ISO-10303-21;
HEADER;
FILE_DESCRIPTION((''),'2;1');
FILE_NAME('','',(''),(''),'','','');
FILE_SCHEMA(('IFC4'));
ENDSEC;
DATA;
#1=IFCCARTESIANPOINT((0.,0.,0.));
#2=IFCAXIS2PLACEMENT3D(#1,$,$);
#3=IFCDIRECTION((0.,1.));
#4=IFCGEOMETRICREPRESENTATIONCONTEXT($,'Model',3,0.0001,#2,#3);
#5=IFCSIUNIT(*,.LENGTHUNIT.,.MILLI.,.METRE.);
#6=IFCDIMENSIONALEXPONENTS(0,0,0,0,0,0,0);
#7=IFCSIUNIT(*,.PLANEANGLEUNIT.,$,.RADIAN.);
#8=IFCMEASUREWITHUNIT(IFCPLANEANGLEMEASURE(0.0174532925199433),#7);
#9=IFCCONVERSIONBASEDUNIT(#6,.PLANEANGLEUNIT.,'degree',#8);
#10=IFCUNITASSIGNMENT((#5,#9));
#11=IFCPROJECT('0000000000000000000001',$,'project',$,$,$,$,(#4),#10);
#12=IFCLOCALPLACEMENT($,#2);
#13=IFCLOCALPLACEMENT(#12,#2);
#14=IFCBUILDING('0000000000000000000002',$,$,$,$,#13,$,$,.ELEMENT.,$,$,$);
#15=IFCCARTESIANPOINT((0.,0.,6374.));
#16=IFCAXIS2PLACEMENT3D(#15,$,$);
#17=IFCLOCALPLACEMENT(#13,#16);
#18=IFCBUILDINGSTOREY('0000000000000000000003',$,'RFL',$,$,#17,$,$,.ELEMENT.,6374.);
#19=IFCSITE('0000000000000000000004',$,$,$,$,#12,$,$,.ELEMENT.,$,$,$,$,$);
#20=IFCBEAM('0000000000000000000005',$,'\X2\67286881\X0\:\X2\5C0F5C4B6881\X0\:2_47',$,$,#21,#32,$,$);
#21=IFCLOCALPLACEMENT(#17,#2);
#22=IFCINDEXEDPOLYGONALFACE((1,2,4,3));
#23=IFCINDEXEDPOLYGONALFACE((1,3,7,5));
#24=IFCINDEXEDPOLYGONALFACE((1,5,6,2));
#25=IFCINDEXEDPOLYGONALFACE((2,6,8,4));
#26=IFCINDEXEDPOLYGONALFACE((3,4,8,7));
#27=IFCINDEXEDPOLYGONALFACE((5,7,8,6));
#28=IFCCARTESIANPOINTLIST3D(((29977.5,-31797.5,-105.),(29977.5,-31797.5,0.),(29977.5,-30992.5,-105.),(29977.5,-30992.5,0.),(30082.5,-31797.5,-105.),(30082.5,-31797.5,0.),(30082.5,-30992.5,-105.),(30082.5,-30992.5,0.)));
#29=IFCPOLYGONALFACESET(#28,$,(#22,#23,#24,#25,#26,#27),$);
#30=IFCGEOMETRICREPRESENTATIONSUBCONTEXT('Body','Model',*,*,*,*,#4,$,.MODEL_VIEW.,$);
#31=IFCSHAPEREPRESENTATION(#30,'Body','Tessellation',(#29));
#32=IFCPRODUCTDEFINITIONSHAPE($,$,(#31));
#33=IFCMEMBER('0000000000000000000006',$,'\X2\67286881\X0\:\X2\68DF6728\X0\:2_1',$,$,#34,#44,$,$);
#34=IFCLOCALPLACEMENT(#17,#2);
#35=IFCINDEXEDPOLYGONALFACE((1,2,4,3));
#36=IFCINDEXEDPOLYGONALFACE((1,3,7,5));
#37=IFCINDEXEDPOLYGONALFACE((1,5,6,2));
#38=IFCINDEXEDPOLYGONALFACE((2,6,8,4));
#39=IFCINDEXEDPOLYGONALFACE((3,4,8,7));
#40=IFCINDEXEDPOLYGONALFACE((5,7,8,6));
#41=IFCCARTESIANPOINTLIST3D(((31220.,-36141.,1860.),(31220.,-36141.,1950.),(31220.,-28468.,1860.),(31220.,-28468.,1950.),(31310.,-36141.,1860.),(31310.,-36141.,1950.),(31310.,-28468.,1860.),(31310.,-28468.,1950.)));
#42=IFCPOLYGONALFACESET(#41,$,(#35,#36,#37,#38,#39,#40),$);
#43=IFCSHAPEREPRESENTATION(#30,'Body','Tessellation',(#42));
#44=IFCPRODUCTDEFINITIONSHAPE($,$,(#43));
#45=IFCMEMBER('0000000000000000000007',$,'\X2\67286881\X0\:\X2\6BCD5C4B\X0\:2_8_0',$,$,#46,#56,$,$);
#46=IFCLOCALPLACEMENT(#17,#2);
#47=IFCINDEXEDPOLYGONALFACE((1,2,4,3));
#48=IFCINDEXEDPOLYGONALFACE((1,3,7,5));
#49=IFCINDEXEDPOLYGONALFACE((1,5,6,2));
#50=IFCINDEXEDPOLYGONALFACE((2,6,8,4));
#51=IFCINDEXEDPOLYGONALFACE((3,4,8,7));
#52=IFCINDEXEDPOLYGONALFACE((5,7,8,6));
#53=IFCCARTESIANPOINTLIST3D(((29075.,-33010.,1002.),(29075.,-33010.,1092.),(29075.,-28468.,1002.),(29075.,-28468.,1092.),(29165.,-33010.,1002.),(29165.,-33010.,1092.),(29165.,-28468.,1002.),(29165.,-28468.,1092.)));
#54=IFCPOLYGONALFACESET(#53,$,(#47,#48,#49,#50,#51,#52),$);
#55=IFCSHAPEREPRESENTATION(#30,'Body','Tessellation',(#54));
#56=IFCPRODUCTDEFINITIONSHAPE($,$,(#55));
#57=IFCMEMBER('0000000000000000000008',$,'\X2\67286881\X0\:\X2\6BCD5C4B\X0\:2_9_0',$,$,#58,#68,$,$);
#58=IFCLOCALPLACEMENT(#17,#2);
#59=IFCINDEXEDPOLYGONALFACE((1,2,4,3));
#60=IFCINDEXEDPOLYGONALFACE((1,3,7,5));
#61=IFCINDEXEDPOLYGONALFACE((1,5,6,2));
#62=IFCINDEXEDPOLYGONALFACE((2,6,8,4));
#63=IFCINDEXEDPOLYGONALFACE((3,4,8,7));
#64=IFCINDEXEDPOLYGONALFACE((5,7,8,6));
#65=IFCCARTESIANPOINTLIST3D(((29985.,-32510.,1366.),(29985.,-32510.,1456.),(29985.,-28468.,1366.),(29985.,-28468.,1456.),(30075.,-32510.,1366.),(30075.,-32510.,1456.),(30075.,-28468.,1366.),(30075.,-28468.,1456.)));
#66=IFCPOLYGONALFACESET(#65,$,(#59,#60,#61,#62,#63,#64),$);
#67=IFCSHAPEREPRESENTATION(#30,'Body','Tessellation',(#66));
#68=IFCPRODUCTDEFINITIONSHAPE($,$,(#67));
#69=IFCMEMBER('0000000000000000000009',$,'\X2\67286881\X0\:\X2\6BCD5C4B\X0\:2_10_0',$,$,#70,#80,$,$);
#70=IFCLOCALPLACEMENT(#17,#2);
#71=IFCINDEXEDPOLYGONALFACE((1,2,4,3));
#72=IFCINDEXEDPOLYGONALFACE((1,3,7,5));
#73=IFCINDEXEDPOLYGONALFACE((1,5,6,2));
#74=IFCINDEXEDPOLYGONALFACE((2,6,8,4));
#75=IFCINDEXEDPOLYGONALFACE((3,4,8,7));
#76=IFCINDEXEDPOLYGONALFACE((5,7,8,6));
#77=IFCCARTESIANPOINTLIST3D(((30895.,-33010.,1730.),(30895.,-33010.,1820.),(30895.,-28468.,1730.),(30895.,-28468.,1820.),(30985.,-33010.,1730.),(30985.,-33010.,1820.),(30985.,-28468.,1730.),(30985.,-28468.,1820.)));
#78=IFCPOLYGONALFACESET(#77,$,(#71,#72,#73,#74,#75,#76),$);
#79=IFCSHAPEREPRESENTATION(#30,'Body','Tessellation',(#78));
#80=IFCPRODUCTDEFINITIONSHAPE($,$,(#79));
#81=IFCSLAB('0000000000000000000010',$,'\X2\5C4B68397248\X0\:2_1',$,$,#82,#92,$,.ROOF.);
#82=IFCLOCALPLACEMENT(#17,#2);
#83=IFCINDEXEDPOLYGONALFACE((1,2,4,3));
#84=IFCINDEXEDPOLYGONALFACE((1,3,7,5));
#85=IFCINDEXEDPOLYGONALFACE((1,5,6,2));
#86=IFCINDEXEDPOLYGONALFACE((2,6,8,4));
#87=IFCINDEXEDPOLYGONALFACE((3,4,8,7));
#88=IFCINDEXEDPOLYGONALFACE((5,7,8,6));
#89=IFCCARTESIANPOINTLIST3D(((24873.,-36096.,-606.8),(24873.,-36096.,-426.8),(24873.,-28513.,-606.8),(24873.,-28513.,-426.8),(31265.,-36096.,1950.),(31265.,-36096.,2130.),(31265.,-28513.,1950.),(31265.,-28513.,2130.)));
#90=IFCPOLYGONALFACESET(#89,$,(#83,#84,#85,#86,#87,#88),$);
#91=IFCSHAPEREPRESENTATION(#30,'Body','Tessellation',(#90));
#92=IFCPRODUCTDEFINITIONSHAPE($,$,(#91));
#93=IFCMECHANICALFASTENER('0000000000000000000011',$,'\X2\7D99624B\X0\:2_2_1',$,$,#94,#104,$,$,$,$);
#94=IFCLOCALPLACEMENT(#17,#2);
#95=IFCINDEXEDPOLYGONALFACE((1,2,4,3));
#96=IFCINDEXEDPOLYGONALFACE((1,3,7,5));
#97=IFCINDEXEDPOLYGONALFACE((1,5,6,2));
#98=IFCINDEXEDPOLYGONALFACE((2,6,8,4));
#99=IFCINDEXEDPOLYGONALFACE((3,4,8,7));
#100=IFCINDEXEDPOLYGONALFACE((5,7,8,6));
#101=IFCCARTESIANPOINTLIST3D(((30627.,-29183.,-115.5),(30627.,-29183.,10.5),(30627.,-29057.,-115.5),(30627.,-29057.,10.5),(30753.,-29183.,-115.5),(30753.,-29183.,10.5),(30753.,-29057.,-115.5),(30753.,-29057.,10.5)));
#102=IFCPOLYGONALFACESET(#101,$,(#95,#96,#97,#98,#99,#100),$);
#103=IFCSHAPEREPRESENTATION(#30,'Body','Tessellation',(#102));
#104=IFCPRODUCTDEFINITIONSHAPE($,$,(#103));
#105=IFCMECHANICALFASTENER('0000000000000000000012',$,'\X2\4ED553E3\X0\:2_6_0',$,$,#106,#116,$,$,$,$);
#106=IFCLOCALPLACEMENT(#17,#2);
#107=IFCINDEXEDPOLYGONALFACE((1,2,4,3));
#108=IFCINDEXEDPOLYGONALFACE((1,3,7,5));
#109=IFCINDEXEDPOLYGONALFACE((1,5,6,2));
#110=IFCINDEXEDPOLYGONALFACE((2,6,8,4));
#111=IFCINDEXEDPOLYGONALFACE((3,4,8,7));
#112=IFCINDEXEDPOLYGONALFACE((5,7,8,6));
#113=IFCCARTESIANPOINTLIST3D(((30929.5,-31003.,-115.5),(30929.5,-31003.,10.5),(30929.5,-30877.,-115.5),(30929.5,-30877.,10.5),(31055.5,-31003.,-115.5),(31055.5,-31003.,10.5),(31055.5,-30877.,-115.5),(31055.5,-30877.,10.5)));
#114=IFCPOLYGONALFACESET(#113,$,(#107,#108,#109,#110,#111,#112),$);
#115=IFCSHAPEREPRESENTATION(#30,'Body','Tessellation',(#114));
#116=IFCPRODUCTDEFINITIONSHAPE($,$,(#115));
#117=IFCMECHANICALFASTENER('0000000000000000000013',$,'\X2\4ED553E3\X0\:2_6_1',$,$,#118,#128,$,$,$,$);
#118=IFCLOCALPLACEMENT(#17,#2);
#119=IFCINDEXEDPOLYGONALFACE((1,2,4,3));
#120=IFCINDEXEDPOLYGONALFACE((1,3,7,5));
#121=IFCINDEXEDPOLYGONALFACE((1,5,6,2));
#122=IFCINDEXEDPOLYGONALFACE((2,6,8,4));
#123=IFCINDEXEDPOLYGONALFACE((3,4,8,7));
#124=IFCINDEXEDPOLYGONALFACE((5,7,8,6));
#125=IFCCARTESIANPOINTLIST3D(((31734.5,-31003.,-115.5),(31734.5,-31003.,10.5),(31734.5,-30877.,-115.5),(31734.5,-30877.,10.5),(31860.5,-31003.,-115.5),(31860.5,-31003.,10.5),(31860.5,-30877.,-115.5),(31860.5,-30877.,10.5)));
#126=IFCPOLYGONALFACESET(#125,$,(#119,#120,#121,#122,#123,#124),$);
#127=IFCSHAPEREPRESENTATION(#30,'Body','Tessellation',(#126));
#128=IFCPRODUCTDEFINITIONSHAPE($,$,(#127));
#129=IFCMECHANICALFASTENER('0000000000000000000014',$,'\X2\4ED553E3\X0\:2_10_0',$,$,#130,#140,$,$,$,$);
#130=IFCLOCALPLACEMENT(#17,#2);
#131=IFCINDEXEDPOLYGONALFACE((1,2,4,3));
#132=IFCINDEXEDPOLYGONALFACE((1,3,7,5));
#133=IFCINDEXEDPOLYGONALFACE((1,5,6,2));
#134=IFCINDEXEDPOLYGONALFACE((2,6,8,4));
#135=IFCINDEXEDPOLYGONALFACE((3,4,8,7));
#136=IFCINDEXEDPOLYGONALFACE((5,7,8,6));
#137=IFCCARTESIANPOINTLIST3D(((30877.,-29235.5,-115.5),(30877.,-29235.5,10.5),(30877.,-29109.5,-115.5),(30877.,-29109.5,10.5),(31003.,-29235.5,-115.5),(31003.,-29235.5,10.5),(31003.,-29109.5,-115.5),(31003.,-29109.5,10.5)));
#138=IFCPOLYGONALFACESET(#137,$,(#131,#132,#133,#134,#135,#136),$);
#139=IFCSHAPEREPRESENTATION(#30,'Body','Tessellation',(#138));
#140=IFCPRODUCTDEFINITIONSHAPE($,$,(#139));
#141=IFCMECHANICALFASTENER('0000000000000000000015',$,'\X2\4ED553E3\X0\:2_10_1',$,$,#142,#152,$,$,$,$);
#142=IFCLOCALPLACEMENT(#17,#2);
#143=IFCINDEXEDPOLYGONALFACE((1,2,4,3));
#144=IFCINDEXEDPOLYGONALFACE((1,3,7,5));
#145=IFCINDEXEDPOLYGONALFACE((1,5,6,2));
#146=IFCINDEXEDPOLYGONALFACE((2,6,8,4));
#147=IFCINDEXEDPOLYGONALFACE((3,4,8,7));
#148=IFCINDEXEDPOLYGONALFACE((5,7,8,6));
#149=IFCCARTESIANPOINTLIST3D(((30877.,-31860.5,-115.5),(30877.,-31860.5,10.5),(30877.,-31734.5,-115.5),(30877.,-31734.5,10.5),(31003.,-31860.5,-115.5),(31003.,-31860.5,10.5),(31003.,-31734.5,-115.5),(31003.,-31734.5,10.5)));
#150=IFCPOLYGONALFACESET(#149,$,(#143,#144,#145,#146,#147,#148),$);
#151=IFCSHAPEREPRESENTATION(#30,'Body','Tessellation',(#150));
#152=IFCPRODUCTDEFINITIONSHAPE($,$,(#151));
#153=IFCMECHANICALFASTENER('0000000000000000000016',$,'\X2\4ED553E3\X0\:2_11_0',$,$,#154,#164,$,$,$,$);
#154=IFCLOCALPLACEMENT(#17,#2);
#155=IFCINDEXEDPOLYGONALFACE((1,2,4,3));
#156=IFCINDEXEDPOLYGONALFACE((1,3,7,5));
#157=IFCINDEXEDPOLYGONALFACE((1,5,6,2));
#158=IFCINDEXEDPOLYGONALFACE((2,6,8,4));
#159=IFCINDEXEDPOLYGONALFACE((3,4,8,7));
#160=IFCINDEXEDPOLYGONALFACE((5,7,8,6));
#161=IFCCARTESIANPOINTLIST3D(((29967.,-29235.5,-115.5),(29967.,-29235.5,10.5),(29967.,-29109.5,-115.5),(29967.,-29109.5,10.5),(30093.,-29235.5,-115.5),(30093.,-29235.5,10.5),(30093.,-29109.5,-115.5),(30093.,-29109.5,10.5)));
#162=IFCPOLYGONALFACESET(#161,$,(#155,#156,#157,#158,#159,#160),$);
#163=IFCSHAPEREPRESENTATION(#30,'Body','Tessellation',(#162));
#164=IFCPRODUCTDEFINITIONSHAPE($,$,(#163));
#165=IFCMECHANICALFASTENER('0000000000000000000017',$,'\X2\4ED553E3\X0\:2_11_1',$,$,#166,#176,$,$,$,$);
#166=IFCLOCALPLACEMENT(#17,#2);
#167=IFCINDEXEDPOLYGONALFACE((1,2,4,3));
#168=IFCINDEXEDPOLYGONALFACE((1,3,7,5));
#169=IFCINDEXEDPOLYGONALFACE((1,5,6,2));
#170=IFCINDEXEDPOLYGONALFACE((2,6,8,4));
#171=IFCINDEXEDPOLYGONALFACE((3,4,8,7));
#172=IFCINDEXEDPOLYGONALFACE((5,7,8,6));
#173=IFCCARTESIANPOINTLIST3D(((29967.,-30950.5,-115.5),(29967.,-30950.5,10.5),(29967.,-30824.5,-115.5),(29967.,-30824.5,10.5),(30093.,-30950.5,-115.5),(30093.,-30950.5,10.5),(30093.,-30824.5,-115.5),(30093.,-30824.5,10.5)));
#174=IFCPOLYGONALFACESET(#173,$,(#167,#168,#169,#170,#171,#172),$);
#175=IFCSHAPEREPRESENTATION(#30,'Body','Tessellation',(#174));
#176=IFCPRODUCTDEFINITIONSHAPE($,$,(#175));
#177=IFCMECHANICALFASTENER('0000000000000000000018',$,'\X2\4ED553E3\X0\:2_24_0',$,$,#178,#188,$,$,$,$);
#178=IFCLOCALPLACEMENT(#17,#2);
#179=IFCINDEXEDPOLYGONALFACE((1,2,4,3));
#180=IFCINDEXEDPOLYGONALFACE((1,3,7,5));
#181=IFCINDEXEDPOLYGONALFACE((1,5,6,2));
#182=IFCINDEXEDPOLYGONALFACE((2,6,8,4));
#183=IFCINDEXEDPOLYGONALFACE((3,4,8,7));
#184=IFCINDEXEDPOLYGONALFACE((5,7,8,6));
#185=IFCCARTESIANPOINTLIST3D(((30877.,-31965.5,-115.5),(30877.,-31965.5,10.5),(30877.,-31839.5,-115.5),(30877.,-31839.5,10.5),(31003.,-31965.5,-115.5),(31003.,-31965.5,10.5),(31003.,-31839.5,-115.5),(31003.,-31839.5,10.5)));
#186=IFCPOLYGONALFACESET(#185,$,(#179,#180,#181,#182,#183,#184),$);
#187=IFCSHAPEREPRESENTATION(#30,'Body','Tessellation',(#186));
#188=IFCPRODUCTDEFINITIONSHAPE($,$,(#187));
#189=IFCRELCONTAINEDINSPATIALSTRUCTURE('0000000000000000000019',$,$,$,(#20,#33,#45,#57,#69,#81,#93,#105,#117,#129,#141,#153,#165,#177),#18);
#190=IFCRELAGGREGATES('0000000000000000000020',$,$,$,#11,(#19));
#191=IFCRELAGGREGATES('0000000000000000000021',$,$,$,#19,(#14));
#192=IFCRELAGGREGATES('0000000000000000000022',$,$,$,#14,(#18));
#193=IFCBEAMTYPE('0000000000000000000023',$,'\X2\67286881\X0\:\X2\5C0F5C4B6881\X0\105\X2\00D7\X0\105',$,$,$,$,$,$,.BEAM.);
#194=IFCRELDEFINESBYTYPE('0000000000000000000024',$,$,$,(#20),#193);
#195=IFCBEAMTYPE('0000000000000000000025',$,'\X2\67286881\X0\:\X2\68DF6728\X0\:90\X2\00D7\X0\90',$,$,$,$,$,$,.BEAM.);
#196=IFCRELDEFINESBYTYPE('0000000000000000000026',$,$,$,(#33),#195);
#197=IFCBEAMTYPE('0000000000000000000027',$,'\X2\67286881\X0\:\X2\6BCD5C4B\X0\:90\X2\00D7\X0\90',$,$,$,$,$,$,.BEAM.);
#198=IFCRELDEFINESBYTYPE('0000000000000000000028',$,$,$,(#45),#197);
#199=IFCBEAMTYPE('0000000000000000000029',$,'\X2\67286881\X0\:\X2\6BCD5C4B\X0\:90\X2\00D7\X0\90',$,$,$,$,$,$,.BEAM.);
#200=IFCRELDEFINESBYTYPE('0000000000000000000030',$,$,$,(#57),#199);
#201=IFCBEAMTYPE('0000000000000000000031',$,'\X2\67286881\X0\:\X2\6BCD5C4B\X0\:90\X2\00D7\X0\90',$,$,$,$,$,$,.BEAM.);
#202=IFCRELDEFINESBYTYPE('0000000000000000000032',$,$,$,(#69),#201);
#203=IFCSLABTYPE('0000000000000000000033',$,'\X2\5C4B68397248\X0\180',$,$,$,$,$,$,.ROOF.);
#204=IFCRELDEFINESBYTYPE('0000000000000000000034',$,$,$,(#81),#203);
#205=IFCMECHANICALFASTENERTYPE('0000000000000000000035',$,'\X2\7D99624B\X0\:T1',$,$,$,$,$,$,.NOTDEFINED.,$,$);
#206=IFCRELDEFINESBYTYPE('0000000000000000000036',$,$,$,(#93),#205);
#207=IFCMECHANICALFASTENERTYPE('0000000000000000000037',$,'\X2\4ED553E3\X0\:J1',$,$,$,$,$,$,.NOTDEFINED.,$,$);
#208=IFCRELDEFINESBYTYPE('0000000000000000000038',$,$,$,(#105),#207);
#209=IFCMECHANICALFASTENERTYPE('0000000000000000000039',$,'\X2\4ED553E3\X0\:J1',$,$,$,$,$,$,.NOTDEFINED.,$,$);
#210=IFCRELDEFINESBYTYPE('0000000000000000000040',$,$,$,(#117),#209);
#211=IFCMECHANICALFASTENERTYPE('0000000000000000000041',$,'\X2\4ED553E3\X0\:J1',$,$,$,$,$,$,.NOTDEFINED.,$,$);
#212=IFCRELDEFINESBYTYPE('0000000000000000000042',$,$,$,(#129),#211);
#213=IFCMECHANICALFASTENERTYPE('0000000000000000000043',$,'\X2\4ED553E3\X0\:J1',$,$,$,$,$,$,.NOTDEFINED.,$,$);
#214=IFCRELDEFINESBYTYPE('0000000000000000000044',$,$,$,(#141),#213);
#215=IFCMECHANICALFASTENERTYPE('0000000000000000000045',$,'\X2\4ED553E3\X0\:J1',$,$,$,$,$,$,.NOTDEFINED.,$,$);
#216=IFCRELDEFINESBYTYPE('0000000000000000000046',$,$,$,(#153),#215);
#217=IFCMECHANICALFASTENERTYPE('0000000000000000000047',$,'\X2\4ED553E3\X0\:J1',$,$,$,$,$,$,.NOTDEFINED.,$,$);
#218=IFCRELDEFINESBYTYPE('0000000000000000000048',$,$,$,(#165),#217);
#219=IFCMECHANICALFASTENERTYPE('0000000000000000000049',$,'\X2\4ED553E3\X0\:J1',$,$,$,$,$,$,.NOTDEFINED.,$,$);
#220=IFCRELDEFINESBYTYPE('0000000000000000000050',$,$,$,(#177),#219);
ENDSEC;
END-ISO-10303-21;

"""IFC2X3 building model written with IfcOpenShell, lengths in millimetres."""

from ifc_helpers import new_model, entity, si_unit, converted_unit, direction, frame, origin, origin_with_axes, origin_2d, place, context, subcontext, project, spatial, polyline, rectangle, outline, extrude, type_object, element, save


model = new_model("IFC2X3")

# Units and contexts
model_context = context("Model", 3, precision=0.0001, world=origin(), true_north=direction((0.0, 1.0)))
body_context = subcontext(model_context, "Body", "Model", "MODEL_VIEW")
ifc_project = project(units=[si_unit("LENGTHUNIT", "METRE", prefix="MILLI"), converted_unit("PLANEANGLEUNIT", "degree", entity("IfcPlaneAngleMeasure", 0.0174532925199433), si_unit("PLANEANGLEUNIT", "RADIAN"), dimensions=[0, 0, 0, 0, 0, 0, 0])], contexts=[model_context])

# Site, building, storey
site_placement = place(None, origin())
site = spatial("IfcSite", under=ifc_project, at=site_placement, CompositionType="ELEMENT")
building_placement = place(site_placement, origin())
building = spatial("IfcBuilding", under=site, at=building_placement, CompositionType="ELEMENT")
storey_placement = place(building_placement, frame((0.0, 0.0, 6374.0)))
storey = spatial("IfcBuildingStorey", under=building, at=storey_placement, Name="RFL", CompositionType="ELEMENT", Elevation=6374.0)

# Beam
beam_type_1 = type_object("IfcBeamType", Name="木梁:小屋梁105×105", PredefinedType="BEAM")
beam_1_placement = place(storey_placement, frame((30030.0, -30992.5, -52.5), z_axis=(0.0, -1.0, 0.0), x_axis=(1.0, 0.0, 0.0)))
element("IfcBeam", 1, at=beam_1_placement, inside=storey, type_object=beam_type_1, Name="木梁:小屋梁:2_47", context=body_context, shape_type="SweptSolid", body=[
    extrude(rectangle(XDim=105.0, YDim=105.0, at=origin_2d()), origin_with_axes(), (0.0, 0.0, 1.0), 805.0),
])

# Members
beam_type_2 = type_object("IfcBeamType", Name="木梁:棟木:90×90", PredefinedType="BEAM")
member_1_placement = place(storey_placement, frame((31265.0, -28468.0, 1905.0), z_axis=(0.0, -1.0, 0.0), x_axis=(-1.0, 0.0, 0.0)))
element("IfcMember", 2, at=member_1_placement, inside=storey, type_object=beam_type_2, Name="木梁:棟木:2_1", context=body_context, shape_type="SweptSolid", body=[
    extrude(rectangle(XDim=90.0, YDim=90.0, at=origin_2d()), origin_with_axes(), (0.0, 0.0, 1.0), 7673.0),
])
beam_type_3 = type_object("IfcBeamType", Name="木梁:母屋:90×90", PredefinedType="BEAM")
member_2_placement = place(storey_placement, frame((29120.0, -28468.0, 1047.0), z_axis=(0.0, -1.0, 0.0), x_axis=(-1.0, 0.0, 0.0)))
element("IfcMember", 3, at=member_2_placement, inside=storey, type_object=beam_type_3, Name="木梁:母屋:2_8_0", context=body_context, shape_type="SweptSolid", body=[
    extrude(rectangle(XDim=90.0, YDim=90.0, at=origin_2d()), origin_with_axes(), (0.0, 0.0, 1.0), 4542.0),
])
beam_type_4 = type_object("IfcBeamType", Name="木梁:母屋:90×90", PredefinedType="BEAM")
member_3_placement = place(storey_placement, frame((30030.0, -28468.0, 1411.0), z_axis=(0.0, -1.0, 0.0), x_axis=(-1.0, 0.0, 0.0)))
element("IfcMember", 4, at=member_3_placement, inside=storey, type_object=beam_type_4, Name="木梁:母屋:2_9_0", context=body_context, shape_type="SweptSolid", body=[
    extrude(rectangle(XDim=90.0, YDim=90.0, at=origin_2d()), origin_with_axes(), (0.0, 0.0, 1.0), 4042.0),
])
beam_type_5 = type_object("IfcBeamType", Name="木梁:母屋:90×90", PredefinedType="BEAM")
member_4_placement = place(storey_placement, frame((30940.0, -28468.0, 1775.0), z_axis=(0.0, -1.0, 0.0), x_axis=(-1.0, 0.0, 0.0)))
element("IfcMember", 5, at=member_4_placement, inside=storey, type_object=beam_type_5, Name="木梁:母屋:2_10_0", context=body_context, shape_type="SweptSolid", body=[
    extrude(rectangle(XDim=90.0, YDim=90.0, at=origin_2d()), origin_with_axes(), (0.0, 0.0, 1.0), 4542.0),
])

# Slab
slab_type = type_object("IfcSlabType", Name="屋根版180", PredefinedType="ROOF")
slab_placement = place(storey_placement, frame((31265.0, -28513.0, 1950.0), z_axis=(0.371391, 0.0, -0.928477), x_axis=(0.0, -1.0, 0.0)))
element("IfcSlab", 6, at=slab_placement, inside=storey, type_object=slab_type, Name="屋根版:2_1", PredefinedType="ROOF", context=body_context, shape_type="SweptSolid", body=[
    extrude(outline(polyline([(0.0, 0.0, 0.0), (7583.0, 0.0, 0.0), (7583.0, 6884.4, 0.0), (0.0, 6884.4, 0.0), (0.0, 0.0, 0.0)])), origin_with_axes(), (0.0, -0.371391, -0.928477), 180.0),
])

# Mechanical fasteners
mechanical_fastener_type_1 = type_object("IfcMechanicalFastenerType", Name="継手:T1")
mechanical_fastener_1_placement = place(storey_placement, frame((30690.0, -29120.0, -115.5)))
element("IfcMechanicalFastener", 7, at=mechanical_fastener_1_placement, inside=storey, type_object=mechanical_fastener_type_1, Name="継手:2_2_1", context=body_context, shape_type="SweptSolid", body=[
    extrude(rectangle(XDim=126.0, YDim=126.0, at=origin_2d()), origin_with_axes(), (0.0, 0.0, 1.0), 126.0),
])
mechanical_fastener_type_2 = type_object("IfcMechanicalFastenerType", Name="仕口:J1")
mechanical_fastener_2_placement = place(storey_placement, frame((30992.5, -30940.0, -115.5)))
element("IfcMechanicalFastener", 8, at=mechanical_fastener_2_placement, inside=storey, type_object=mechanical_fastener_type_2, Name="仕口:2_6_0", context=body_context, shape_type="SweptSolid", body=[
    extrude(rectangle(XDim=126.0, YDim=126.0, at=origin_2d()), origin_with_axes(), (0.0, 0.0, 1.0), 126.0),
])
mechanical_fastener_type_3 = type_object("IfcMechanicalFastenerType", Name="仕口:J1")
mechanical_fastener_3_placement = place(storey_placement, frame((31797.5, -30940.0, -115.5)))
element("IfcMechanicalFastener", 9, at=mechanical_fastener_3_placement, inside=storey, type_object=mechanical_fastener_type_3, Name="仕口:2_6_1", context=body_context, shape_type="SweptSolid", body=[
    extrude(rectangle(XDim=126.0, YDim=126.0, at=origin_2d()), origin_with_axes(), (0.0, 0.0, 1.0), 126.0),
])
mechanical_fastener_type_4 = type_object("IfcMechanicalFastenerType", Name="仕口:J1")
mechanical_fastener_4_placement = place(storey_placement, frame((30940.0, -29172.5, -115.5)))
element("IfcMechanicalFastener", 10, at=mechanical_fastener_4_placement, inside=storey, type_object=mechanical_fastener_type_4, Name="仕口:2_10_0", context=body_context, shape_type="SweptSolid", body=[
    extrude(rectangle(XDim=126.0, YDim=126.0, at=origin_2d()), origin_with_axes(), (0.0, 0.0, 1.0), 126.0),
])
mechanical_fastener_type_5 = type_object("IfcMechanicalFastenerType", Name="仕口:J1")
mechanical_fastener_5_placement = place(storey_placement, frame((30940.0, -31797.5, -115.5)))
element("IfcMechanicalFastener", 11, at=mechanical_fastener_5_placement, inside=storey, type_object=mechanical_fastener_type_5, Name="仕口:2_10_1", context=body_context, shape_type="SweptSolid", body=[
    extrude(rectangle(XDim=126.0, YDim=126.0, at=origin_2d()), origin_with_axes(), (0.0, 0.0, 1.0), 126.0),
])
mechanical_fastener_type_6 = type_object("IfcMechanicalFastenerType", Name="仕口:J1")
mechanical_fastener_6_placement = place(storey_placement, frame((30030.0, -29172.5, -115.5)))
element("IfcMechanicalFastener", 12, at=mechanical_fastener_6_placement, inside=storey, type_object=mechanical_fastener_type_6, Name="仕口:2_11_0", context=body_context, shape_type="SweptSolid", body=[
    extrude(rectangle(XDim=126.0, YDim=126.0, at=origin_2d()), origin_with_axes(), (0.0, 0.0, 1.0), 126.0),
])
mechanical_fastener_type_7 = type_object("IfcMechanicalFastenerType", Name="仕口:J1")
mechanical_fastener_7_placement = place(storey_placement, frame((30030.0, -30887.5, -115.5)))
element("IfcMechanicalFastener", 13, at=mechanical_fastener_7_placement, inside=storey, type_object=mechanical_fastener_type_7, Name="仕口:2_11_1", context=body_context, shape_type="SweptSolid", body=[
    extrude(rectangle(XDim=126.0, YDim=126.0, at=origin_2d()), origin_with_axes(), (0.0, 0.0, 1.0), 126.0),
])
mechanical_fastener_type_8 = type_object("IfcMechanicalFastenerType", Name="仕口:J1")
mechanical_fastener_8_placement = place(storey_placement, frame((30940.0, -31902.5, -115.5)))
element("IfcMechanicalFastener", 14, at=mechanical_fastener_8_placement, inside=storey, type_object=mechanical_fastener_type_8, Name="仕口:2_24_0", context=body_context, shape_type="SweptSolid", body=[
    extrude(rectangle(XDim=126.0, YDim=126.0, at=origin_2d()), origin_with_axes(), (0.0, 0.0, 1.0), 126.0),
])

save(model, "model.ifc")
